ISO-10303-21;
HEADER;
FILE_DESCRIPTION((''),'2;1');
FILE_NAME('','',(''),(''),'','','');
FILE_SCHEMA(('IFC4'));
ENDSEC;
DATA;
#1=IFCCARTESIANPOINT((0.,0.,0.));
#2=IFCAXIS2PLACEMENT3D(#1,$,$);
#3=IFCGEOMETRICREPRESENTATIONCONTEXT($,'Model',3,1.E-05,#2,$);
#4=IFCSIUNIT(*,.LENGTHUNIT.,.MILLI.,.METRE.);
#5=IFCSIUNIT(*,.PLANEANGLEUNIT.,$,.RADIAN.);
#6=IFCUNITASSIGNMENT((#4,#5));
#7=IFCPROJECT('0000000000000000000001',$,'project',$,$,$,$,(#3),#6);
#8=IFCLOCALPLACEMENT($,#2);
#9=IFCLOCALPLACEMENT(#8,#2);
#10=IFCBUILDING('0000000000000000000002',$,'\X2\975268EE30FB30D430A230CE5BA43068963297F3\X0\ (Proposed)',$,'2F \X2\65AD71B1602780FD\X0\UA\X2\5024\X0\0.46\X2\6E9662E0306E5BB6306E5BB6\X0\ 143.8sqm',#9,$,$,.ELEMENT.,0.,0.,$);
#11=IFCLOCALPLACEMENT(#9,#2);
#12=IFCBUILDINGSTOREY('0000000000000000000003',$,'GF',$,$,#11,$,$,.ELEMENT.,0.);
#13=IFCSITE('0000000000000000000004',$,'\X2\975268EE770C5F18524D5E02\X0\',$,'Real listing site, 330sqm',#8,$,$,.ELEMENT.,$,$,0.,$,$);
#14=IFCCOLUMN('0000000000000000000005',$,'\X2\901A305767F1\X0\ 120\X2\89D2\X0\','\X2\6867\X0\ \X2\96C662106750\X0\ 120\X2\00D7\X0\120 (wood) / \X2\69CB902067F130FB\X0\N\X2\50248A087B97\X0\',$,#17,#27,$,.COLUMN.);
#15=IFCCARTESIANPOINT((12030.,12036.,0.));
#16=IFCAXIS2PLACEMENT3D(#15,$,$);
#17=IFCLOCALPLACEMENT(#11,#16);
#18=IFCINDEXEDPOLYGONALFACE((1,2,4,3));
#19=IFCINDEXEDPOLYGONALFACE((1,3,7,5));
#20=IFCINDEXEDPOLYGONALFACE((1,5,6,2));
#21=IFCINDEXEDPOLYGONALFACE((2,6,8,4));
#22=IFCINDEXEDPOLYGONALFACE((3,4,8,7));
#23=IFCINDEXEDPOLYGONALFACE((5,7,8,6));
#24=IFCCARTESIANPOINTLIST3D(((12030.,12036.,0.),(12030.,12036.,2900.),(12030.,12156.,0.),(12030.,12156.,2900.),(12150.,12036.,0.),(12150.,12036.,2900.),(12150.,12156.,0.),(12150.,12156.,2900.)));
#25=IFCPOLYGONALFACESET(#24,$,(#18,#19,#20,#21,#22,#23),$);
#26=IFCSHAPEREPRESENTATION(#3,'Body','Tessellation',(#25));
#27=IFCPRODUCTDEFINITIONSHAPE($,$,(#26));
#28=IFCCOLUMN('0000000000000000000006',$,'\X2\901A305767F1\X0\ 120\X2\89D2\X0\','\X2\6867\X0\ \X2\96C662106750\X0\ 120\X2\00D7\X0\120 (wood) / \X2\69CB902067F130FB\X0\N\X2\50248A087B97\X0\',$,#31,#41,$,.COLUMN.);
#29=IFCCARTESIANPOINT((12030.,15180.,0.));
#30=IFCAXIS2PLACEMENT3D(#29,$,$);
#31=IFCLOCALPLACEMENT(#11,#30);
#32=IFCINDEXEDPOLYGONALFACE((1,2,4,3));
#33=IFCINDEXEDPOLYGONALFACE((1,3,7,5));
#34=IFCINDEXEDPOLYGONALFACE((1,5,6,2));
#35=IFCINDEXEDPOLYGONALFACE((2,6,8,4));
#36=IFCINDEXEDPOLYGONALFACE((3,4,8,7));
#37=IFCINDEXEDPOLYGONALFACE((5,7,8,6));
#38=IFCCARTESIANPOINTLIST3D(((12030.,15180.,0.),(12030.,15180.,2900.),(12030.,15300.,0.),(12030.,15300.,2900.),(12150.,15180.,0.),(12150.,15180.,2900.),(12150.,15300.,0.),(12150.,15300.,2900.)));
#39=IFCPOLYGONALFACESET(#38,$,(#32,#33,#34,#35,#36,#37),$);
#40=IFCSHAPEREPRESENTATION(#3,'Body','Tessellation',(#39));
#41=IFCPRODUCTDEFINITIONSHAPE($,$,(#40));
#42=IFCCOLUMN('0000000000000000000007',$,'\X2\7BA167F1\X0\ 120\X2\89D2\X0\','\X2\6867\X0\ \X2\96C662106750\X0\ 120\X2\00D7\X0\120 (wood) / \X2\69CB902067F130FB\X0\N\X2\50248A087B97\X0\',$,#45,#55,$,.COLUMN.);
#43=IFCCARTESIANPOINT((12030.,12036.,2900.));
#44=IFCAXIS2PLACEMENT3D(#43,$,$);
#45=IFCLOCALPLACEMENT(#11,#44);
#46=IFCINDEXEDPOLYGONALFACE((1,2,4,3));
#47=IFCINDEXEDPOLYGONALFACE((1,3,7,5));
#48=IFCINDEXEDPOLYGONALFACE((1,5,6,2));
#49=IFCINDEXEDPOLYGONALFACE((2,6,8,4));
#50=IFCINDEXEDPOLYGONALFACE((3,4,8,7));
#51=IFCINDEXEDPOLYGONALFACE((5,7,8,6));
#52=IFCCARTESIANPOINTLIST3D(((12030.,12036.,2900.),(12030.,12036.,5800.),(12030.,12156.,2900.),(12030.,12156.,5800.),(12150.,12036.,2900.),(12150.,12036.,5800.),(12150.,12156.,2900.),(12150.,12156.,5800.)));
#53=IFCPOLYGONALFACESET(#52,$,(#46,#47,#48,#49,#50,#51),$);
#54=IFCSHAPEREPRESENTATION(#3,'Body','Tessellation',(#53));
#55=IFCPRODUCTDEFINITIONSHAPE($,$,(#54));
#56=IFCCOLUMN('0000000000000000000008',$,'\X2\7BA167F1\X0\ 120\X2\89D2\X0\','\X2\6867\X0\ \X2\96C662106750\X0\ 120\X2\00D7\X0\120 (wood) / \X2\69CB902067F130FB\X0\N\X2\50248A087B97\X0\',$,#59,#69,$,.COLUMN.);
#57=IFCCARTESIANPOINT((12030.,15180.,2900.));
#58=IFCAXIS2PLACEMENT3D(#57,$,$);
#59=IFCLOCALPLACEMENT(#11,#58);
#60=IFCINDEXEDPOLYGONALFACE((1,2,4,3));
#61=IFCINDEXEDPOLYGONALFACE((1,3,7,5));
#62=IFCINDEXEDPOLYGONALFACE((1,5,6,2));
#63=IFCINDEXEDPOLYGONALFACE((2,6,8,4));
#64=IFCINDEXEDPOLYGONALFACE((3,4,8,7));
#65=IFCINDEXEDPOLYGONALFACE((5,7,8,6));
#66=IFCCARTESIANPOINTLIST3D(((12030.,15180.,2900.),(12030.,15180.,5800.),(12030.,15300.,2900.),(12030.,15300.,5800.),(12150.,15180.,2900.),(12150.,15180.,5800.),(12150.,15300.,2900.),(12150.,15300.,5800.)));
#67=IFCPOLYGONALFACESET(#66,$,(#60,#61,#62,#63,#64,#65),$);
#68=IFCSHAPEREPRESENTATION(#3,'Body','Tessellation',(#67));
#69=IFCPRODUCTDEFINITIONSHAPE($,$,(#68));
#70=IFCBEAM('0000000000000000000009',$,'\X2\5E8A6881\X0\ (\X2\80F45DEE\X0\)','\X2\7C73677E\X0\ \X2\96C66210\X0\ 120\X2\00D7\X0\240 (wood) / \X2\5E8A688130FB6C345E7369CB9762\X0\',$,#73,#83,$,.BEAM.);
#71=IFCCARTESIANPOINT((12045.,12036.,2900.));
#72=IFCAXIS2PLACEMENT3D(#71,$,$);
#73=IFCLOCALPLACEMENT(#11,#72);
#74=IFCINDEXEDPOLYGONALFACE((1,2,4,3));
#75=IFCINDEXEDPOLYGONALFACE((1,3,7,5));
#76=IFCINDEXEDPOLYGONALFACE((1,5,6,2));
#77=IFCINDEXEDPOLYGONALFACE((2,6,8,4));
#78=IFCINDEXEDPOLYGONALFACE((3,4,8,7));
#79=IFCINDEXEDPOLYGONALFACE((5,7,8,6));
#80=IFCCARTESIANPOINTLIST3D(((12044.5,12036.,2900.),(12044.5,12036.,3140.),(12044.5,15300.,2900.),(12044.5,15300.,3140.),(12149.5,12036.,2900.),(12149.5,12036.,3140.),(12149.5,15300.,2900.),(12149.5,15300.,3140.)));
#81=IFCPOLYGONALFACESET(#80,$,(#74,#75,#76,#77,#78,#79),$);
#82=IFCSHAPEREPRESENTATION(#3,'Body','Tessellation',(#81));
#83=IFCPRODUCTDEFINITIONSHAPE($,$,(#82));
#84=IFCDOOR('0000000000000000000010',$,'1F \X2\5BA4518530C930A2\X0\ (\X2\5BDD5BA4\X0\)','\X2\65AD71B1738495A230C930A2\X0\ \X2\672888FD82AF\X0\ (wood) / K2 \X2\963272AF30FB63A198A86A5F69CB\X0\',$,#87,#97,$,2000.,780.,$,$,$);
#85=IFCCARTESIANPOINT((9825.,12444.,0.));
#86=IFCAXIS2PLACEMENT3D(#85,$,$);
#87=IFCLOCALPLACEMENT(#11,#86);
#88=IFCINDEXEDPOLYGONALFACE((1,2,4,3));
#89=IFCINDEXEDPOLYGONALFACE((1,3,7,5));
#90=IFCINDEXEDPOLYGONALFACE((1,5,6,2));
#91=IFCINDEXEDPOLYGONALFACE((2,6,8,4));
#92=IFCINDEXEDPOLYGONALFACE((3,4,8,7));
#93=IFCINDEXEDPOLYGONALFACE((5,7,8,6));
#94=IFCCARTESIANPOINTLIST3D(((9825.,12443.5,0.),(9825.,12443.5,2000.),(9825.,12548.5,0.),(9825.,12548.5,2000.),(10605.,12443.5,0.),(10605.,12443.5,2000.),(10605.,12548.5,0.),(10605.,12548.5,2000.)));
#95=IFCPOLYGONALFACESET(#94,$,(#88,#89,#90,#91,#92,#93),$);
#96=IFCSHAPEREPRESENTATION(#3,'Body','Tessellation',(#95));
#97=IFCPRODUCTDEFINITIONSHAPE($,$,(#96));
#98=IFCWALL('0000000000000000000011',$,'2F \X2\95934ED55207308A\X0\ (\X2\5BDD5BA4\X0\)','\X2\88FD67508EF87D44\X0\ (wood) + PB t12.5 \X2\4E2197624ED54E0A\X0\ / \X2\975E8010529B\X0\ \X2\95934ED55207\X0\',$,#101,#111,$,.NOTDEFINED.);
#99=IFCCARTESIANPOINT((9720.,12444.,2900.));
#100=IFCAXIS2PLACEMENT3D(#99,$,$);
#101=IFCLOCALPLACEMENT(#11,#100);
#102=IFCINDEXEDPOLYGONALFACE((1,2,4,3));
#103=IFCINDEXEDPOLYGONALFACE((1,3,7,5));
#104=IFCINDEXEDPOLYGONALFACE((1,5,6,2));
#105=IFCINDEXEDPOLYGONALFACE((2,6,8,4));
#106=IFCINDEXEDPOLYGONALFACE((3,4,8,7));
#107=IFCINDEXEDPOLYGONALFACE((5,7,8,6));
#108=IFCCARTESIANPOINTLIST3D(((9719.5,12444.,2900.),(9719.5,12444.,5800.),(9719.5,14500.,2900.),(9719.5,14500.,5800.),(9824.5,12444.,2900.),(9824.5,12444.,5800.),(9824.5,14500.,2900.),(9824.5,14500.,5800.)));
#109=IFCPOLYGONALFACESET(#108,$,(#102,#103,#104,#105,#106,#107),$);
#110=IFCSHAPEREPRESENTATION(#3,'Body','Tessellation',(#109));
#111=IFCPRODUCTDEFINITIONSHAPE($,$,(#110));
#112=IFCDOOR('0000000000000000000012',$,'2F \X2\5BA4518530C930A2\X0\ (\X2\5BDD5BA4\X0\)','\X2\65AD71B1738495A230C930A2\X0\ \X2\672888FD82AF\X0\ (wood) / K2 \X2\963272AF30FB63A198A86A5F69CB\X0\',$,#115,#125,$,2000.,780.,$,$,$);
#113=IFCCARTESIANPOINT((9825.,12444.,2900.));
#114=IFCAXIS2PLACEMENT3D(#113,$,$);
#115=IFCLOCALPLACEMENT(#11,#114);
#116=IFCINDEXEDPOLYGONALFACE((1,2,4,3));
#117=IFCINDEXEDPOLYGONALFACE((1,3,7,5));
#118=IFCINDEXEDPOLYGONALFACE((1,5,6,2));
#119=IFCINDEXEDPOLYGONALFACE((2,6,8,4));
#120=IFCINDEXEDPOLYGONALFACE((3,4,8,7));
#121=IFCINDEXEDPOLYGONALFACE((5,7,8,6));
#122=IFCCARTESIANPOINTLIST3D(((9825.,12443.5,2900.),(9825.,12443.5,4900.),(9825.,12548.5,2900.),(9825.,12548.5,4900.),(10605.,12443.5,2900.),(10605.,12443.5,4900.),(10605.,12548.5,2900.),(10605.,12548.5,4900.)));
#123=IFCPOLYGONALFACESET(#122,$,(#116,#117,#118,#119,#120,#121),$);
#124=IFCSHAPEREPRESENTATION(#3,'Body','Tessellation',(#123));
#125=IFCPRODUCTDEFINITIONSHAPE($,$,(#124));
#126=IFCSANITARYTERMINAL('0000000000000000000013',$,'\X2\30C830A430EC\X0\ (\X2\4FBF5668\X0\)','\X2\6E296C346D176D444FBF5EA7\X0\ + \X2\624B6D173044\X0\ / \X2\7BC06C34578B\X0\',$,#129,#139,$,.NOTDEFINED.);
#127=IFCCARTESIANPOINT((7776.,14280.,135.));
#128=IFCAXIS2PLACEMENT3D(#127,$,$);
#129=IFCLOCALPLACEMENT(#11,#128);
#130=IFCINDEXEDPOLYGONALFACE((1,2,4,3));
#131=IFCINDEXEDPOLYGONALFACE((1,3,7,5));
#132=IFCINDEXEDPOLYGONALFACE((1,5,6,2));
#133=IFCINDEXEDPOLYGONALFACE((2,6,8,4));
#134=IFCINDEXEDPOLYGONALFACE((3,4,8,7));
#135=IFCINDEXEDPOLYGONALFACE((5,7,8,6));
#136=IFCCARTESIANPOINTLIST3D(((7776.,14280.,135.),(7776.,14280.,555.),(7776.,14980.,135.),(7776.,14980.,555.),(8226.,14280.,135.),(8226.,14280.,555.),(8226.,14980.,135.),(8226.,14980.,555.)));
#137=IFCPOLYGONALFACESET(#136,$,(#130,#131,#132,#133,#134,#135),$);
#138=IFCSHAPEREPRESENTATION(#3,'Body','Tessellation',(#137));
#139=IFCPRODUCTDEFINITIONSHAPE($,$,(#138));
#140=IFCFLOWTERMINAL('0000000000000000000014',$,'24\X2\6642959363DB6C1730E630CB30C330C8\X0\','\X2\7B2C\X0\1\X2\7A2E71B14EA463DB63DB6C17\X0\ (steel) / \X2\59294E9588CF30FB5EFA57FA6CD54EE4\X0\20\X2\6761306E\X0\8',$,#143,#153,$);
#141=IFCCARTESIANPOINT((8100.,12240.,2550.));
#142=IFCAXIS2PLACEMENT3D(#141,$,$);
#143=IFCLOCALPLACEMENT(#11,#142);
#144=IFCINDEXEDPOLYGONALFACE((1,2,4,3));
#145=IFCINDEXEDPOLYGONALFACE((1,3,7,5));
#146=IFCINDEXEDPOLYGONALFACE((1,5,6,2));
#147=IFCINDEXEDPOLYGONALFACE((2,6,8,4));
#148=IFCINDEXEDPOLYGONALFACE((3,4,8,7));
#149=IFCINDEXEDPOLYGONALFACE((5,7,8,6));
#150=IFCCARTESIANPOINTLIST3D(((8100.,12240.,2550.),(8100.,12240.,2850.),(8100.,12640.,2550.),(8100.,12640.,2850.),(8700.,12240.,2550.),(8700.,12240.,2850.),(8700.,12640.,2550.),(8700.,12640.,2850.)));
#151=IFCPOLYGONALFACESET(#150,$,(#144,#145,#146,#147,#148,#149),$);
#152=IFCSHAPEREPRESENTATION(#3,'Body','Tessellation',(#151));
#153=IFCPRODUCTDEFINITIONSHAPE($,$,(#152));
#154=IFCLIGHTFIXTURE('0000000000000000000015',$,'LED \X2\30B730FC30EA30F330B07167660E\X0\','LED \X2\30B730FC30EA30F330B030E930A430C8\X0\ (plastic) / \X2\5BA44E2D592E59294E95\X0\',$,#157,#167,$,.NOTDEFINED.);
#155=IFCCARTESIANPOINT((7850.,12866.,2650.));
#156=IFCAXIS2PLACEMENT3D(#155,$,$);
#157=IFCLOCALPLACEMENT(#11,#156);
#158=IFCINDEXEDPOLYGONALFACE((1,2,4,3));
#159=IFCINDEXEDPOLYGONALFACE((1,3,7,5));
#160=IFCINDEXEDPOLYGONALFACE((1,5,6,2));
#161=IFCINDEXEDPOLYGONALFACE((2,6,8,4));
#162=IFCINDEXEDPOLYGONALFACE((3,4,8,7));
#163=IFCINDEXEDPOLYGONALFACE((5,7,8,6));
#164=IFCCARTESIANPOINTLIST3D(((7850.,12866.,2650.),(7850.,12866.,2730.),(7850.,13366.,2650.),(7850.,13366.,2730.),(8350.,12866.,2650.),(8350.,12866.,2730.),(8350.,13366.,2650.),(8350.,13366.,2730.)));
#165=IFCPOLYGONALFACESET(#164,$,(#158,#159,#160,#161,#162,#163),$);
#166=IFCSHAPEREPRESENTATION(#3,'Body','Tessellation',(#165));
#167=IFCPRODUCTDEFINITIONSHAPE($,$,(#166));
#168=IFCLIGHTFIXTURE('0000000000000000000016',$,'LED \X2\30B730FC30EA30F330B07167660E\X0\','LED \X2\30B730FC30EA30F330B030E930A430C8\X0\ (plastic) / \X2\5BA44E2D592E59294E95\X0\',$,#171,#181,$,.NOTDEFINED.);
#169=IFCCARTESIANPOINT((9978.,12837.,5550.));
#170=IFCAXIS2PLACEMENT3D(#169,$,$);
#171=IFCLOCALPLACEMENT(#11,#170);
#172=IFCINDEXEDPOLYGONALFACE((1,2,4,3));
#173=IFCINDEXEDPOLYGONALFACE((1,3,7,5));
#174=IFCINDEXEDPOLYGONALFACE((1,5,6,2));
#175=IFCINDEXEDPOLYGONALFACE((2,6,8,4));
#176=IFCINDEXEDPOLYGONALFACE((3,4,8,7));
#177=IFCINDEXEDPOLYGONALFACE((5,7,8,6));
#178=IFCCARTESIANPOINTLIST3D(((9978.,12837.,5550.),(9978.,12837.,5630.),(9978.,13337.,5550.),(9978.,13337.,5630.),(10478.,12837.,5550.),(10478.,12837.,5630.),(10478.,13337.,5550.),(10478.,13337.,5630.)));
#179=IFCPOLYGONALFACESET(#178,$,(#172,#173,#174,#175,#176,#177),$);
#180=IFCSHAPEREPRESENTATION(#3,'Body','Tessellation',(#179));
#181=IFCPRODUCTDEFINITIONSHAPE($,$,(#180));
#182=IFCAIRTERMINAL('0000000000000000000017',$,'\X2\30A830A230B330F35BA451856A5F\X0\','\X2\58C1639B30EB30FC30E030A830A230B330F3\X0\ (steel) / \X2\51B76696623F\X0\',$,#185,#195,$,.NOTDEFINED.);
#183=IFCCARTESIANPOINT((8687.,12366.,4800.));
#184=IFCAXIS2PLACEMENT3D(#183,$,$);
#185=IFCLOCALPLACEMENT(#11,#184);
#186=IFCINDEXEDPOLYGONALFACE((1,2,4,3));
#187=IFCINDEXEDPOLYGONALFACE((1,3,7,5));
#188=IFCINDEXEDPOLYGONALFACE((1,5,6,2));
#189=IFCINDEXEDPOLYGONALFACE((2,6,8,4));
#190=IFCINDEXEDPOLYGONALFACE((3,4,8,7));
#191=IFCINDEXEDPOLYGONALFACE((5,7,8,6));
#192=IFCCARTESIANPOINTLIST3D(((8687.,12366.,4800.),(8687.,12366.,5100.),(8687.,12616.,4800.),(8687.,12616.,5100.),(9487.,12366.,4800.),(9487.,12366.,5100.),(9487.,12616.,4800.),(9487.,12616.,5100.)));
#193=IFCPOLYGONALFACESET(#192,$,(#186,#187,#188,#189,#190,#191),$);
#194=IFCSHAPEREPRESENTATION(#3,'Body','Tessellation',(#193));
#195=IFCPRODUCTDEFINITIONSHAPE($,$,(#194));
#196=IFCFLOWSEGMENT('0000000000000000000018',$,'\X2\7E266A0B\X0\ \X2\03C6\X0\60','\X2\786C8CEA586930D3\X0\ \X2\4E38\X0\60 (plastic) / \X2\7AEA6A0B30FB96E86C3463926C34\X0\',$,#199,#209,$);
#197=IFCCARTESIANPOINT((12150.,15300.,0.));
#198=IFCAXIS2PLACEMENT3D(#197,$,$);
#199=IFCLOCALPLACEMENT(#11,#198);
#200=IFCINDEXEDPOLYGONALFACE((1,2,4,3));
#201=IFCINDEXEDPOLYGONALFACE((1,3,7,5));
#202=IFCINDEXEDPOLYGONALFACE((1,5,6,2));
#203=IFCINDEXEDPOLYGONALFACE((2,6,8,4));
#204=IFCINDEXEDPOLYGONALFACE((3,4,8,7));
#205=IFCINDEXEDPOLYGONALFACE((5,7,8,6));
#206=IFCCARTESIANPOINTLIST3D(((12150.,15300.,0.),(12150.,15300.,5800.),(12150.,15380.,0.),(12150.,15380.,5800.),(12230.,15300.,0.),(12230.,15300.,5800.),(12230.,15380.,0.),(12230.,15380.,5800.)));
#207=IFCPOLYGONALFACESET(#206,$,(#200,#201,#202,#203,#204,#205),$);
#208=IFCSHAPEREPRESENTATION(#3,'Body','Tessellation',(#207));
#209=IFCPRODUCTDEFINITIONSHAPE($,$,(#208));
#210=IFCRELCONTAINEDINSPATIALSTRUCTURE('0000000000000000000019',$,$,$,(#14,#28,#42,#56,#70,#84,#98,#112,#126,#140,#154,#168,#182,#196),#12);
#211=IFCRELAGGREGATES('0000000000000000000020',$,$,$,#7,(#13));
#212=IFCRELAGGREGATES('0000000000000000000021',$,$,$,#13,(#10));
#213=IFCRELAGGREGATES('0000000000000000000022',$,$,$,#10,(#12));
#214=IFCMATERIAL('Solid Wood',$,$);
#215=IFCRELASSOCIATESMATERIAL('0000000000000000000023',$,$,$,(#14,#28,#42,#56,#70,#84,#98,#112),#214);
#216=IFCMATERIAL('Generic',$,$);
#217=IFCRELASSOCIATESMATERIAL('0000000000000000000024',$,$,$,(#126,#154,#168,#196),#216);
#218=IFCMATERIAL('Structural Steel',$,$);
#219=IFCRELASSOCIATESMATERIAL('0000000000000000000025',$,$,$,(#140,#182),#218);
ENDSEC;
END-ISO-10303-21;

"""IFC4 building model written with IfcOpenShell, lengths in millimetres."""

from ifc_helpers import new_model, si_unit, frame, frame_2d, origin, place, context, project, spatial, rectangle, extrude, material, element, save


model = new_model("IFC4")

# Units and contexts
model_context = context("Model", 3, precision=1e-05, world=origin())
ifc_project = project(units=[si_unit("LENGTHUNIT", "METRE", prefix="MILLI"), si_unit("PLANEANGLEUNIT", "RADIAN")], contexts=[model_context])

# Site, building, storey
site_placement = place(None, origin())
site = spatial("IfcSite", under=ifc_project, at=site_placement, Name="青森県弘前市", ObjectType="Real listing site, 330sqm", CompositionType="ELEMENT", RefElevation=0.0)
building_placement = place(site_placement, origin())
building = spatial("IfcBuilding", under=site, at=building_placement, Name="青森・ピアノ室と防音 (Proposed)", ObjectType="2F 断熱性能UA値0.46準拠の家の家 143.8sqm", CompositionType="ELEMENT", ElevationOfRefHeight=0.0, ElevationOfTerrain=0.0)
storey_placement = place(building_placement, origin())
storey = spatial("IfcBuildingStorey", under=building, at=storey_placement, Name="GF", CompositionType="ELEMENT", Elevation=0.0)

# Columns
ifc_material_1 = material(Name="Solid Wood")
column_1_placement = place(storey_placement, frame((12030.0, 12036.0, 0.0)))
element("IfcColumn", 1, at=column_1_placement, inside=storey, material=ifc_material_1, Name="通し柱 120角", Description="桧 集成材 120×120 (wood) / 構造柱・N値計算", PredefinedType="COLUMN", context=model_context, shape_type="SweptSolid", body=[
    extrude(rectangle(XDim=120.0, YDim=120.0, at=frame_2d((60.0, 60.0))), frame((12030.0, 12036.0, 0.0)), (0.0, 0.0, 1.0), 2900.0),
])
column_2_placement = place(storey_placement, frame((12030.0, 15180.0, 0.0)))
element("IfcColumn", 2, at=column_2_placement, inside=storey, material=ifc_material_1, Name="通し柱 120角", Description="桧 集成材 120×120 (wood) / 構造柱・N値計算", PredefinedType="COLUMN", context=model_context, shape_type="SweptSolid", body=[
    extrude(rectangle(XDim=120.0, YDim=120.0, at=frame_2d((60.0, 60.0))), frame((12030.0, 15180.0, 0.0)), (0.0, 0.0, 1.0), 2900.0),
])
column_3_placement = place(storey_placement, frame((12030.0, 12036.0, 2900.0)))
element("IfcColumn", 3, at=column_3_placement, inside=storey, material=ifc_material_1, Name="管柱 120角", Description="桧 集成材 120×120 (wood) / 構造柱・N値計算", PredefinedType="COLUMN", context=model_context, shape_type="SweptSolid", body=[
    extrude(rectangle(XDim=120.0, YDim=120.0, at=frame_2d((60.0, 60.0))), frame((12030.0, 12036.0, 2900.0)), (0.0, 0.0, 1.0), 2900.0),
])
column_4_placement = place(storey_placement, frame((12030.0, 15180.0, 2900.0)))
element("IfcColumn", 4, at=column_4_placement, inside=storey, material=ifc_material_1, Name="管柱 120角", Description="桧 集成材 120×120 (wood) / 構造柱・N値計算", PredefinedType="COLUMN", context=model_context, shape_type="SweptSolid", body=[
    extrude(rectangle(XDim=120.0, YDim=120.0, at=frame_2d((60.0, 60.0))), frame((12030.0, 15180.0, 2900.0)), (0.0, 0.0, 1.0), 2900.0),
])

# Beam
beam_1_placement = place(storey_placement, frame((12045.0, 12036.0, 2900.0)))
element("IfcBeam", 5, at=beam_1_placement, inside=storey, material=ifc_material_1, Name="床梁 (胴差)", Description="米松 集成 120×240 (wood) / 床梁・水平構面", PredefinedType="BEAM", context=model_context, shape_type="SweptSolid", body=[
    extrude(rectangle(XDim=105.0, YDim=3264.0, at=frame_2d((52.0, 1632.0))), frame((12045.0, 12036.0, 2900.0)), (0.0, 0.0, 1.0), 240.0),
])

# Door
door_1_placement = place(storey_placement, frame((9825.0, 12444.0, 0.0)))
element("IfcDoor", 6, at=door_1_placement, inside=storey, material=ifc_material_1, Name="1F 室内ドア (寝室)", Description="断熱玄関ドア 木製芯 (wood) / K2 防犯・採風機構", OverallHeight=2000.0, OverallWidth=780.0, context=model_context, shape_type="SweptSolid", body=[
    extrude(rectangle(XDim=780.0, YDim=105.0, at=frame_2d((390.0, 52.0))), frame((9825.0, 12444.0, 0.0)), (0.0, 0.0, 1.0), 2000.0),
])

# Wall
wall_1_placement = place(storey_placement, frame((9720.0, 12444.0, 2900.0)))
element("IfcWall", 7, at=wall_1_placement, inside=storey, material=ifc_material_1, Name="2F 間仕切り (寝室)", Description="製材軸組 (wood) + PB t12.5 両面仕上 / 非耐力 間仕切", PredefinedType="NOTDEFINED", context=model_context, shape_type="SweptSolid", body=[
    extrude(rectangle(XDim=105.0, YDim=2056.0, at=frame_2d((52.0, 1028.0))), frame((9720.0, 12444.0, 2900.0)), (0.0, 0.0, 1.0), 2900.0),
])

# Door
door_2_placement = place(storey_placement, frame((9825.0, 12444.0, 2900.0)))
element("IfcDoor", 8, at=door_2_placement, inside=storey, material=ifc_material_1, Name="2F 室内ドア (寝室)", Description="断熱玄関ドア 木製芯 (wood) / K2 防犯・採風機構", OverallHeight=2000.0, OverallWidth=780.0, context=model_context, shape_type="SweptSolid", body=[
    extrude(rectangle(XDim=780.0, YDim=105.0, at=frame_2d((390.0, 52.0))), frame((9825.0, 12444.0, 2900.0)), (0.0, 0.0, 1.0), 2000.0),
])

# Sanitary terminal
ifc_material_2 = material(Name="Generic")
sanitary_terminal_placement = place(storey_placement, frame((7776.0, 14280.0, 135.0)))
element("IfcSanitaryTerminal", 9, at=sanitary_terminal_placement, inside=storey, material=ifc_material_2, Name="トイレ (便器)", Description="温水洗浄便座 + 手洗い / 節水型", PredefinedType="NOTDEFINED", context=model_context, shape_type="SweptSolid", body=[
    extrude(rectangle(XDim=450.0, YDim=700.0, at=frame_2d((225.0, 350.0))), frame((7776.0, 14280.0, 135.0)), (0.0, 0.0, 1.0), 420.0),
])

# Flow terminal
ifc_material_3 = material(Name="Structural Steel")
flow_terminal_placement = place(storey_placement, frame((8100.0, 12240.0, 2550.0)))
element("IfcFlowTerminal", 10, at=flow_terminal_placement, inside=storey, material=ifc_material_3, Name="24時間換気ユニット", Description="第1種熱交換換気 (steel) / 天井裏・建基法令20条の8", context=model_context, shape_type="SweptSolid", body=[
    extrude(rectangle(XDim=600.0, YDim=400.0, at=frame_2d((300.0, 200.0))), frame((8100.0, 12240.0, 2550.0)), (0.0, 0.0, 1.0), 300.0),
])

# Light fixtures
light_fixture_1_placement = place(storey_placement, frame((7850.0, 12866.0, 2650.0)))
element("IfcLightFixture", 11, at=light_fixture_1_placement, inside=storey, material=ifc_material_2, Name="LED シーリング照明", Description="LED シーリングライト (plastic) / 室中央天井", PredefinedType="NOTDEFINED", context=model_context, shape_type="SweptSolid", body=[
    extrude(rectangle(XDim=500.0, YDim=500.0, at=frame_2d((250.0, 250.0))), frame((7850.0, 12866.0, 2650.0)), (0.0, 0.0, 1.0), 80.0),
])
light_fixture_2_placement = place(storey_placement, frame((9978.0, 12837.0, 5550.0)))
element("IfcLightFixture", 12, at=light_fixture_2_placement, inside=storey, material=ifc_material_2, Name="LED シーリング照明", Description="LED シーリングライト (plastic) / 室中央天井", PredefinedType="NOTDEFINED", context=model_context, shape_type="SweptSolid", body=[
    extrude(rectangle(XDim=500.0, YDim=500.0, at=frame_2d((250.0, 250.0))), frame((9978.0, 12837.0, 5550.0)), (0.0, 0.0, 1.0), 80.0),
])

# Air terminal
air_terminal_placement = place(storey_placement, frame((8687.0, 12366.0, 4800.0)))
element("IfcAirTerminal", 13, at=air_terminal_placement, inside=storey, material=ifc_material_3, Name="エアコン室内機", Description="壁掛ルームエアコン (steel) / 冷暖房", PredefinedType="NOTDEFINED", context=model_context, shape_type="SweptSolid", body=[
    extrude(rectangle(XDim=800.0, YDim=250.0, at=frame_2d((400.0, 125.0))), frame((8687.0, 12366.0, 4800.0)), (0.0, 0.0, 1.0), 300.0),
])

# Flow segment
flow_segment_placement = place(storey_placement, frame((12150.0, 15300.0, 0.0)))
element("IfcFlowSegment", 14, at=flow_segment_placement, inside=storey, material=ifc_material_2, Name="縦樋 φ60", Description="硬質塩ビ 丸60 (plastic) / 竪樋・雨水排水", context=model_context, shape_type="SweptSolid", body=[
    extrude(rectangle(XDim=80.0, YDim=80.0, at=frame_2d((40.0, 40.0))), frame((12150.0, 15300.0, 0.0)), (0.0, 0.0, 1.0), 5800.0),
])

save(model, "model.ifc")
